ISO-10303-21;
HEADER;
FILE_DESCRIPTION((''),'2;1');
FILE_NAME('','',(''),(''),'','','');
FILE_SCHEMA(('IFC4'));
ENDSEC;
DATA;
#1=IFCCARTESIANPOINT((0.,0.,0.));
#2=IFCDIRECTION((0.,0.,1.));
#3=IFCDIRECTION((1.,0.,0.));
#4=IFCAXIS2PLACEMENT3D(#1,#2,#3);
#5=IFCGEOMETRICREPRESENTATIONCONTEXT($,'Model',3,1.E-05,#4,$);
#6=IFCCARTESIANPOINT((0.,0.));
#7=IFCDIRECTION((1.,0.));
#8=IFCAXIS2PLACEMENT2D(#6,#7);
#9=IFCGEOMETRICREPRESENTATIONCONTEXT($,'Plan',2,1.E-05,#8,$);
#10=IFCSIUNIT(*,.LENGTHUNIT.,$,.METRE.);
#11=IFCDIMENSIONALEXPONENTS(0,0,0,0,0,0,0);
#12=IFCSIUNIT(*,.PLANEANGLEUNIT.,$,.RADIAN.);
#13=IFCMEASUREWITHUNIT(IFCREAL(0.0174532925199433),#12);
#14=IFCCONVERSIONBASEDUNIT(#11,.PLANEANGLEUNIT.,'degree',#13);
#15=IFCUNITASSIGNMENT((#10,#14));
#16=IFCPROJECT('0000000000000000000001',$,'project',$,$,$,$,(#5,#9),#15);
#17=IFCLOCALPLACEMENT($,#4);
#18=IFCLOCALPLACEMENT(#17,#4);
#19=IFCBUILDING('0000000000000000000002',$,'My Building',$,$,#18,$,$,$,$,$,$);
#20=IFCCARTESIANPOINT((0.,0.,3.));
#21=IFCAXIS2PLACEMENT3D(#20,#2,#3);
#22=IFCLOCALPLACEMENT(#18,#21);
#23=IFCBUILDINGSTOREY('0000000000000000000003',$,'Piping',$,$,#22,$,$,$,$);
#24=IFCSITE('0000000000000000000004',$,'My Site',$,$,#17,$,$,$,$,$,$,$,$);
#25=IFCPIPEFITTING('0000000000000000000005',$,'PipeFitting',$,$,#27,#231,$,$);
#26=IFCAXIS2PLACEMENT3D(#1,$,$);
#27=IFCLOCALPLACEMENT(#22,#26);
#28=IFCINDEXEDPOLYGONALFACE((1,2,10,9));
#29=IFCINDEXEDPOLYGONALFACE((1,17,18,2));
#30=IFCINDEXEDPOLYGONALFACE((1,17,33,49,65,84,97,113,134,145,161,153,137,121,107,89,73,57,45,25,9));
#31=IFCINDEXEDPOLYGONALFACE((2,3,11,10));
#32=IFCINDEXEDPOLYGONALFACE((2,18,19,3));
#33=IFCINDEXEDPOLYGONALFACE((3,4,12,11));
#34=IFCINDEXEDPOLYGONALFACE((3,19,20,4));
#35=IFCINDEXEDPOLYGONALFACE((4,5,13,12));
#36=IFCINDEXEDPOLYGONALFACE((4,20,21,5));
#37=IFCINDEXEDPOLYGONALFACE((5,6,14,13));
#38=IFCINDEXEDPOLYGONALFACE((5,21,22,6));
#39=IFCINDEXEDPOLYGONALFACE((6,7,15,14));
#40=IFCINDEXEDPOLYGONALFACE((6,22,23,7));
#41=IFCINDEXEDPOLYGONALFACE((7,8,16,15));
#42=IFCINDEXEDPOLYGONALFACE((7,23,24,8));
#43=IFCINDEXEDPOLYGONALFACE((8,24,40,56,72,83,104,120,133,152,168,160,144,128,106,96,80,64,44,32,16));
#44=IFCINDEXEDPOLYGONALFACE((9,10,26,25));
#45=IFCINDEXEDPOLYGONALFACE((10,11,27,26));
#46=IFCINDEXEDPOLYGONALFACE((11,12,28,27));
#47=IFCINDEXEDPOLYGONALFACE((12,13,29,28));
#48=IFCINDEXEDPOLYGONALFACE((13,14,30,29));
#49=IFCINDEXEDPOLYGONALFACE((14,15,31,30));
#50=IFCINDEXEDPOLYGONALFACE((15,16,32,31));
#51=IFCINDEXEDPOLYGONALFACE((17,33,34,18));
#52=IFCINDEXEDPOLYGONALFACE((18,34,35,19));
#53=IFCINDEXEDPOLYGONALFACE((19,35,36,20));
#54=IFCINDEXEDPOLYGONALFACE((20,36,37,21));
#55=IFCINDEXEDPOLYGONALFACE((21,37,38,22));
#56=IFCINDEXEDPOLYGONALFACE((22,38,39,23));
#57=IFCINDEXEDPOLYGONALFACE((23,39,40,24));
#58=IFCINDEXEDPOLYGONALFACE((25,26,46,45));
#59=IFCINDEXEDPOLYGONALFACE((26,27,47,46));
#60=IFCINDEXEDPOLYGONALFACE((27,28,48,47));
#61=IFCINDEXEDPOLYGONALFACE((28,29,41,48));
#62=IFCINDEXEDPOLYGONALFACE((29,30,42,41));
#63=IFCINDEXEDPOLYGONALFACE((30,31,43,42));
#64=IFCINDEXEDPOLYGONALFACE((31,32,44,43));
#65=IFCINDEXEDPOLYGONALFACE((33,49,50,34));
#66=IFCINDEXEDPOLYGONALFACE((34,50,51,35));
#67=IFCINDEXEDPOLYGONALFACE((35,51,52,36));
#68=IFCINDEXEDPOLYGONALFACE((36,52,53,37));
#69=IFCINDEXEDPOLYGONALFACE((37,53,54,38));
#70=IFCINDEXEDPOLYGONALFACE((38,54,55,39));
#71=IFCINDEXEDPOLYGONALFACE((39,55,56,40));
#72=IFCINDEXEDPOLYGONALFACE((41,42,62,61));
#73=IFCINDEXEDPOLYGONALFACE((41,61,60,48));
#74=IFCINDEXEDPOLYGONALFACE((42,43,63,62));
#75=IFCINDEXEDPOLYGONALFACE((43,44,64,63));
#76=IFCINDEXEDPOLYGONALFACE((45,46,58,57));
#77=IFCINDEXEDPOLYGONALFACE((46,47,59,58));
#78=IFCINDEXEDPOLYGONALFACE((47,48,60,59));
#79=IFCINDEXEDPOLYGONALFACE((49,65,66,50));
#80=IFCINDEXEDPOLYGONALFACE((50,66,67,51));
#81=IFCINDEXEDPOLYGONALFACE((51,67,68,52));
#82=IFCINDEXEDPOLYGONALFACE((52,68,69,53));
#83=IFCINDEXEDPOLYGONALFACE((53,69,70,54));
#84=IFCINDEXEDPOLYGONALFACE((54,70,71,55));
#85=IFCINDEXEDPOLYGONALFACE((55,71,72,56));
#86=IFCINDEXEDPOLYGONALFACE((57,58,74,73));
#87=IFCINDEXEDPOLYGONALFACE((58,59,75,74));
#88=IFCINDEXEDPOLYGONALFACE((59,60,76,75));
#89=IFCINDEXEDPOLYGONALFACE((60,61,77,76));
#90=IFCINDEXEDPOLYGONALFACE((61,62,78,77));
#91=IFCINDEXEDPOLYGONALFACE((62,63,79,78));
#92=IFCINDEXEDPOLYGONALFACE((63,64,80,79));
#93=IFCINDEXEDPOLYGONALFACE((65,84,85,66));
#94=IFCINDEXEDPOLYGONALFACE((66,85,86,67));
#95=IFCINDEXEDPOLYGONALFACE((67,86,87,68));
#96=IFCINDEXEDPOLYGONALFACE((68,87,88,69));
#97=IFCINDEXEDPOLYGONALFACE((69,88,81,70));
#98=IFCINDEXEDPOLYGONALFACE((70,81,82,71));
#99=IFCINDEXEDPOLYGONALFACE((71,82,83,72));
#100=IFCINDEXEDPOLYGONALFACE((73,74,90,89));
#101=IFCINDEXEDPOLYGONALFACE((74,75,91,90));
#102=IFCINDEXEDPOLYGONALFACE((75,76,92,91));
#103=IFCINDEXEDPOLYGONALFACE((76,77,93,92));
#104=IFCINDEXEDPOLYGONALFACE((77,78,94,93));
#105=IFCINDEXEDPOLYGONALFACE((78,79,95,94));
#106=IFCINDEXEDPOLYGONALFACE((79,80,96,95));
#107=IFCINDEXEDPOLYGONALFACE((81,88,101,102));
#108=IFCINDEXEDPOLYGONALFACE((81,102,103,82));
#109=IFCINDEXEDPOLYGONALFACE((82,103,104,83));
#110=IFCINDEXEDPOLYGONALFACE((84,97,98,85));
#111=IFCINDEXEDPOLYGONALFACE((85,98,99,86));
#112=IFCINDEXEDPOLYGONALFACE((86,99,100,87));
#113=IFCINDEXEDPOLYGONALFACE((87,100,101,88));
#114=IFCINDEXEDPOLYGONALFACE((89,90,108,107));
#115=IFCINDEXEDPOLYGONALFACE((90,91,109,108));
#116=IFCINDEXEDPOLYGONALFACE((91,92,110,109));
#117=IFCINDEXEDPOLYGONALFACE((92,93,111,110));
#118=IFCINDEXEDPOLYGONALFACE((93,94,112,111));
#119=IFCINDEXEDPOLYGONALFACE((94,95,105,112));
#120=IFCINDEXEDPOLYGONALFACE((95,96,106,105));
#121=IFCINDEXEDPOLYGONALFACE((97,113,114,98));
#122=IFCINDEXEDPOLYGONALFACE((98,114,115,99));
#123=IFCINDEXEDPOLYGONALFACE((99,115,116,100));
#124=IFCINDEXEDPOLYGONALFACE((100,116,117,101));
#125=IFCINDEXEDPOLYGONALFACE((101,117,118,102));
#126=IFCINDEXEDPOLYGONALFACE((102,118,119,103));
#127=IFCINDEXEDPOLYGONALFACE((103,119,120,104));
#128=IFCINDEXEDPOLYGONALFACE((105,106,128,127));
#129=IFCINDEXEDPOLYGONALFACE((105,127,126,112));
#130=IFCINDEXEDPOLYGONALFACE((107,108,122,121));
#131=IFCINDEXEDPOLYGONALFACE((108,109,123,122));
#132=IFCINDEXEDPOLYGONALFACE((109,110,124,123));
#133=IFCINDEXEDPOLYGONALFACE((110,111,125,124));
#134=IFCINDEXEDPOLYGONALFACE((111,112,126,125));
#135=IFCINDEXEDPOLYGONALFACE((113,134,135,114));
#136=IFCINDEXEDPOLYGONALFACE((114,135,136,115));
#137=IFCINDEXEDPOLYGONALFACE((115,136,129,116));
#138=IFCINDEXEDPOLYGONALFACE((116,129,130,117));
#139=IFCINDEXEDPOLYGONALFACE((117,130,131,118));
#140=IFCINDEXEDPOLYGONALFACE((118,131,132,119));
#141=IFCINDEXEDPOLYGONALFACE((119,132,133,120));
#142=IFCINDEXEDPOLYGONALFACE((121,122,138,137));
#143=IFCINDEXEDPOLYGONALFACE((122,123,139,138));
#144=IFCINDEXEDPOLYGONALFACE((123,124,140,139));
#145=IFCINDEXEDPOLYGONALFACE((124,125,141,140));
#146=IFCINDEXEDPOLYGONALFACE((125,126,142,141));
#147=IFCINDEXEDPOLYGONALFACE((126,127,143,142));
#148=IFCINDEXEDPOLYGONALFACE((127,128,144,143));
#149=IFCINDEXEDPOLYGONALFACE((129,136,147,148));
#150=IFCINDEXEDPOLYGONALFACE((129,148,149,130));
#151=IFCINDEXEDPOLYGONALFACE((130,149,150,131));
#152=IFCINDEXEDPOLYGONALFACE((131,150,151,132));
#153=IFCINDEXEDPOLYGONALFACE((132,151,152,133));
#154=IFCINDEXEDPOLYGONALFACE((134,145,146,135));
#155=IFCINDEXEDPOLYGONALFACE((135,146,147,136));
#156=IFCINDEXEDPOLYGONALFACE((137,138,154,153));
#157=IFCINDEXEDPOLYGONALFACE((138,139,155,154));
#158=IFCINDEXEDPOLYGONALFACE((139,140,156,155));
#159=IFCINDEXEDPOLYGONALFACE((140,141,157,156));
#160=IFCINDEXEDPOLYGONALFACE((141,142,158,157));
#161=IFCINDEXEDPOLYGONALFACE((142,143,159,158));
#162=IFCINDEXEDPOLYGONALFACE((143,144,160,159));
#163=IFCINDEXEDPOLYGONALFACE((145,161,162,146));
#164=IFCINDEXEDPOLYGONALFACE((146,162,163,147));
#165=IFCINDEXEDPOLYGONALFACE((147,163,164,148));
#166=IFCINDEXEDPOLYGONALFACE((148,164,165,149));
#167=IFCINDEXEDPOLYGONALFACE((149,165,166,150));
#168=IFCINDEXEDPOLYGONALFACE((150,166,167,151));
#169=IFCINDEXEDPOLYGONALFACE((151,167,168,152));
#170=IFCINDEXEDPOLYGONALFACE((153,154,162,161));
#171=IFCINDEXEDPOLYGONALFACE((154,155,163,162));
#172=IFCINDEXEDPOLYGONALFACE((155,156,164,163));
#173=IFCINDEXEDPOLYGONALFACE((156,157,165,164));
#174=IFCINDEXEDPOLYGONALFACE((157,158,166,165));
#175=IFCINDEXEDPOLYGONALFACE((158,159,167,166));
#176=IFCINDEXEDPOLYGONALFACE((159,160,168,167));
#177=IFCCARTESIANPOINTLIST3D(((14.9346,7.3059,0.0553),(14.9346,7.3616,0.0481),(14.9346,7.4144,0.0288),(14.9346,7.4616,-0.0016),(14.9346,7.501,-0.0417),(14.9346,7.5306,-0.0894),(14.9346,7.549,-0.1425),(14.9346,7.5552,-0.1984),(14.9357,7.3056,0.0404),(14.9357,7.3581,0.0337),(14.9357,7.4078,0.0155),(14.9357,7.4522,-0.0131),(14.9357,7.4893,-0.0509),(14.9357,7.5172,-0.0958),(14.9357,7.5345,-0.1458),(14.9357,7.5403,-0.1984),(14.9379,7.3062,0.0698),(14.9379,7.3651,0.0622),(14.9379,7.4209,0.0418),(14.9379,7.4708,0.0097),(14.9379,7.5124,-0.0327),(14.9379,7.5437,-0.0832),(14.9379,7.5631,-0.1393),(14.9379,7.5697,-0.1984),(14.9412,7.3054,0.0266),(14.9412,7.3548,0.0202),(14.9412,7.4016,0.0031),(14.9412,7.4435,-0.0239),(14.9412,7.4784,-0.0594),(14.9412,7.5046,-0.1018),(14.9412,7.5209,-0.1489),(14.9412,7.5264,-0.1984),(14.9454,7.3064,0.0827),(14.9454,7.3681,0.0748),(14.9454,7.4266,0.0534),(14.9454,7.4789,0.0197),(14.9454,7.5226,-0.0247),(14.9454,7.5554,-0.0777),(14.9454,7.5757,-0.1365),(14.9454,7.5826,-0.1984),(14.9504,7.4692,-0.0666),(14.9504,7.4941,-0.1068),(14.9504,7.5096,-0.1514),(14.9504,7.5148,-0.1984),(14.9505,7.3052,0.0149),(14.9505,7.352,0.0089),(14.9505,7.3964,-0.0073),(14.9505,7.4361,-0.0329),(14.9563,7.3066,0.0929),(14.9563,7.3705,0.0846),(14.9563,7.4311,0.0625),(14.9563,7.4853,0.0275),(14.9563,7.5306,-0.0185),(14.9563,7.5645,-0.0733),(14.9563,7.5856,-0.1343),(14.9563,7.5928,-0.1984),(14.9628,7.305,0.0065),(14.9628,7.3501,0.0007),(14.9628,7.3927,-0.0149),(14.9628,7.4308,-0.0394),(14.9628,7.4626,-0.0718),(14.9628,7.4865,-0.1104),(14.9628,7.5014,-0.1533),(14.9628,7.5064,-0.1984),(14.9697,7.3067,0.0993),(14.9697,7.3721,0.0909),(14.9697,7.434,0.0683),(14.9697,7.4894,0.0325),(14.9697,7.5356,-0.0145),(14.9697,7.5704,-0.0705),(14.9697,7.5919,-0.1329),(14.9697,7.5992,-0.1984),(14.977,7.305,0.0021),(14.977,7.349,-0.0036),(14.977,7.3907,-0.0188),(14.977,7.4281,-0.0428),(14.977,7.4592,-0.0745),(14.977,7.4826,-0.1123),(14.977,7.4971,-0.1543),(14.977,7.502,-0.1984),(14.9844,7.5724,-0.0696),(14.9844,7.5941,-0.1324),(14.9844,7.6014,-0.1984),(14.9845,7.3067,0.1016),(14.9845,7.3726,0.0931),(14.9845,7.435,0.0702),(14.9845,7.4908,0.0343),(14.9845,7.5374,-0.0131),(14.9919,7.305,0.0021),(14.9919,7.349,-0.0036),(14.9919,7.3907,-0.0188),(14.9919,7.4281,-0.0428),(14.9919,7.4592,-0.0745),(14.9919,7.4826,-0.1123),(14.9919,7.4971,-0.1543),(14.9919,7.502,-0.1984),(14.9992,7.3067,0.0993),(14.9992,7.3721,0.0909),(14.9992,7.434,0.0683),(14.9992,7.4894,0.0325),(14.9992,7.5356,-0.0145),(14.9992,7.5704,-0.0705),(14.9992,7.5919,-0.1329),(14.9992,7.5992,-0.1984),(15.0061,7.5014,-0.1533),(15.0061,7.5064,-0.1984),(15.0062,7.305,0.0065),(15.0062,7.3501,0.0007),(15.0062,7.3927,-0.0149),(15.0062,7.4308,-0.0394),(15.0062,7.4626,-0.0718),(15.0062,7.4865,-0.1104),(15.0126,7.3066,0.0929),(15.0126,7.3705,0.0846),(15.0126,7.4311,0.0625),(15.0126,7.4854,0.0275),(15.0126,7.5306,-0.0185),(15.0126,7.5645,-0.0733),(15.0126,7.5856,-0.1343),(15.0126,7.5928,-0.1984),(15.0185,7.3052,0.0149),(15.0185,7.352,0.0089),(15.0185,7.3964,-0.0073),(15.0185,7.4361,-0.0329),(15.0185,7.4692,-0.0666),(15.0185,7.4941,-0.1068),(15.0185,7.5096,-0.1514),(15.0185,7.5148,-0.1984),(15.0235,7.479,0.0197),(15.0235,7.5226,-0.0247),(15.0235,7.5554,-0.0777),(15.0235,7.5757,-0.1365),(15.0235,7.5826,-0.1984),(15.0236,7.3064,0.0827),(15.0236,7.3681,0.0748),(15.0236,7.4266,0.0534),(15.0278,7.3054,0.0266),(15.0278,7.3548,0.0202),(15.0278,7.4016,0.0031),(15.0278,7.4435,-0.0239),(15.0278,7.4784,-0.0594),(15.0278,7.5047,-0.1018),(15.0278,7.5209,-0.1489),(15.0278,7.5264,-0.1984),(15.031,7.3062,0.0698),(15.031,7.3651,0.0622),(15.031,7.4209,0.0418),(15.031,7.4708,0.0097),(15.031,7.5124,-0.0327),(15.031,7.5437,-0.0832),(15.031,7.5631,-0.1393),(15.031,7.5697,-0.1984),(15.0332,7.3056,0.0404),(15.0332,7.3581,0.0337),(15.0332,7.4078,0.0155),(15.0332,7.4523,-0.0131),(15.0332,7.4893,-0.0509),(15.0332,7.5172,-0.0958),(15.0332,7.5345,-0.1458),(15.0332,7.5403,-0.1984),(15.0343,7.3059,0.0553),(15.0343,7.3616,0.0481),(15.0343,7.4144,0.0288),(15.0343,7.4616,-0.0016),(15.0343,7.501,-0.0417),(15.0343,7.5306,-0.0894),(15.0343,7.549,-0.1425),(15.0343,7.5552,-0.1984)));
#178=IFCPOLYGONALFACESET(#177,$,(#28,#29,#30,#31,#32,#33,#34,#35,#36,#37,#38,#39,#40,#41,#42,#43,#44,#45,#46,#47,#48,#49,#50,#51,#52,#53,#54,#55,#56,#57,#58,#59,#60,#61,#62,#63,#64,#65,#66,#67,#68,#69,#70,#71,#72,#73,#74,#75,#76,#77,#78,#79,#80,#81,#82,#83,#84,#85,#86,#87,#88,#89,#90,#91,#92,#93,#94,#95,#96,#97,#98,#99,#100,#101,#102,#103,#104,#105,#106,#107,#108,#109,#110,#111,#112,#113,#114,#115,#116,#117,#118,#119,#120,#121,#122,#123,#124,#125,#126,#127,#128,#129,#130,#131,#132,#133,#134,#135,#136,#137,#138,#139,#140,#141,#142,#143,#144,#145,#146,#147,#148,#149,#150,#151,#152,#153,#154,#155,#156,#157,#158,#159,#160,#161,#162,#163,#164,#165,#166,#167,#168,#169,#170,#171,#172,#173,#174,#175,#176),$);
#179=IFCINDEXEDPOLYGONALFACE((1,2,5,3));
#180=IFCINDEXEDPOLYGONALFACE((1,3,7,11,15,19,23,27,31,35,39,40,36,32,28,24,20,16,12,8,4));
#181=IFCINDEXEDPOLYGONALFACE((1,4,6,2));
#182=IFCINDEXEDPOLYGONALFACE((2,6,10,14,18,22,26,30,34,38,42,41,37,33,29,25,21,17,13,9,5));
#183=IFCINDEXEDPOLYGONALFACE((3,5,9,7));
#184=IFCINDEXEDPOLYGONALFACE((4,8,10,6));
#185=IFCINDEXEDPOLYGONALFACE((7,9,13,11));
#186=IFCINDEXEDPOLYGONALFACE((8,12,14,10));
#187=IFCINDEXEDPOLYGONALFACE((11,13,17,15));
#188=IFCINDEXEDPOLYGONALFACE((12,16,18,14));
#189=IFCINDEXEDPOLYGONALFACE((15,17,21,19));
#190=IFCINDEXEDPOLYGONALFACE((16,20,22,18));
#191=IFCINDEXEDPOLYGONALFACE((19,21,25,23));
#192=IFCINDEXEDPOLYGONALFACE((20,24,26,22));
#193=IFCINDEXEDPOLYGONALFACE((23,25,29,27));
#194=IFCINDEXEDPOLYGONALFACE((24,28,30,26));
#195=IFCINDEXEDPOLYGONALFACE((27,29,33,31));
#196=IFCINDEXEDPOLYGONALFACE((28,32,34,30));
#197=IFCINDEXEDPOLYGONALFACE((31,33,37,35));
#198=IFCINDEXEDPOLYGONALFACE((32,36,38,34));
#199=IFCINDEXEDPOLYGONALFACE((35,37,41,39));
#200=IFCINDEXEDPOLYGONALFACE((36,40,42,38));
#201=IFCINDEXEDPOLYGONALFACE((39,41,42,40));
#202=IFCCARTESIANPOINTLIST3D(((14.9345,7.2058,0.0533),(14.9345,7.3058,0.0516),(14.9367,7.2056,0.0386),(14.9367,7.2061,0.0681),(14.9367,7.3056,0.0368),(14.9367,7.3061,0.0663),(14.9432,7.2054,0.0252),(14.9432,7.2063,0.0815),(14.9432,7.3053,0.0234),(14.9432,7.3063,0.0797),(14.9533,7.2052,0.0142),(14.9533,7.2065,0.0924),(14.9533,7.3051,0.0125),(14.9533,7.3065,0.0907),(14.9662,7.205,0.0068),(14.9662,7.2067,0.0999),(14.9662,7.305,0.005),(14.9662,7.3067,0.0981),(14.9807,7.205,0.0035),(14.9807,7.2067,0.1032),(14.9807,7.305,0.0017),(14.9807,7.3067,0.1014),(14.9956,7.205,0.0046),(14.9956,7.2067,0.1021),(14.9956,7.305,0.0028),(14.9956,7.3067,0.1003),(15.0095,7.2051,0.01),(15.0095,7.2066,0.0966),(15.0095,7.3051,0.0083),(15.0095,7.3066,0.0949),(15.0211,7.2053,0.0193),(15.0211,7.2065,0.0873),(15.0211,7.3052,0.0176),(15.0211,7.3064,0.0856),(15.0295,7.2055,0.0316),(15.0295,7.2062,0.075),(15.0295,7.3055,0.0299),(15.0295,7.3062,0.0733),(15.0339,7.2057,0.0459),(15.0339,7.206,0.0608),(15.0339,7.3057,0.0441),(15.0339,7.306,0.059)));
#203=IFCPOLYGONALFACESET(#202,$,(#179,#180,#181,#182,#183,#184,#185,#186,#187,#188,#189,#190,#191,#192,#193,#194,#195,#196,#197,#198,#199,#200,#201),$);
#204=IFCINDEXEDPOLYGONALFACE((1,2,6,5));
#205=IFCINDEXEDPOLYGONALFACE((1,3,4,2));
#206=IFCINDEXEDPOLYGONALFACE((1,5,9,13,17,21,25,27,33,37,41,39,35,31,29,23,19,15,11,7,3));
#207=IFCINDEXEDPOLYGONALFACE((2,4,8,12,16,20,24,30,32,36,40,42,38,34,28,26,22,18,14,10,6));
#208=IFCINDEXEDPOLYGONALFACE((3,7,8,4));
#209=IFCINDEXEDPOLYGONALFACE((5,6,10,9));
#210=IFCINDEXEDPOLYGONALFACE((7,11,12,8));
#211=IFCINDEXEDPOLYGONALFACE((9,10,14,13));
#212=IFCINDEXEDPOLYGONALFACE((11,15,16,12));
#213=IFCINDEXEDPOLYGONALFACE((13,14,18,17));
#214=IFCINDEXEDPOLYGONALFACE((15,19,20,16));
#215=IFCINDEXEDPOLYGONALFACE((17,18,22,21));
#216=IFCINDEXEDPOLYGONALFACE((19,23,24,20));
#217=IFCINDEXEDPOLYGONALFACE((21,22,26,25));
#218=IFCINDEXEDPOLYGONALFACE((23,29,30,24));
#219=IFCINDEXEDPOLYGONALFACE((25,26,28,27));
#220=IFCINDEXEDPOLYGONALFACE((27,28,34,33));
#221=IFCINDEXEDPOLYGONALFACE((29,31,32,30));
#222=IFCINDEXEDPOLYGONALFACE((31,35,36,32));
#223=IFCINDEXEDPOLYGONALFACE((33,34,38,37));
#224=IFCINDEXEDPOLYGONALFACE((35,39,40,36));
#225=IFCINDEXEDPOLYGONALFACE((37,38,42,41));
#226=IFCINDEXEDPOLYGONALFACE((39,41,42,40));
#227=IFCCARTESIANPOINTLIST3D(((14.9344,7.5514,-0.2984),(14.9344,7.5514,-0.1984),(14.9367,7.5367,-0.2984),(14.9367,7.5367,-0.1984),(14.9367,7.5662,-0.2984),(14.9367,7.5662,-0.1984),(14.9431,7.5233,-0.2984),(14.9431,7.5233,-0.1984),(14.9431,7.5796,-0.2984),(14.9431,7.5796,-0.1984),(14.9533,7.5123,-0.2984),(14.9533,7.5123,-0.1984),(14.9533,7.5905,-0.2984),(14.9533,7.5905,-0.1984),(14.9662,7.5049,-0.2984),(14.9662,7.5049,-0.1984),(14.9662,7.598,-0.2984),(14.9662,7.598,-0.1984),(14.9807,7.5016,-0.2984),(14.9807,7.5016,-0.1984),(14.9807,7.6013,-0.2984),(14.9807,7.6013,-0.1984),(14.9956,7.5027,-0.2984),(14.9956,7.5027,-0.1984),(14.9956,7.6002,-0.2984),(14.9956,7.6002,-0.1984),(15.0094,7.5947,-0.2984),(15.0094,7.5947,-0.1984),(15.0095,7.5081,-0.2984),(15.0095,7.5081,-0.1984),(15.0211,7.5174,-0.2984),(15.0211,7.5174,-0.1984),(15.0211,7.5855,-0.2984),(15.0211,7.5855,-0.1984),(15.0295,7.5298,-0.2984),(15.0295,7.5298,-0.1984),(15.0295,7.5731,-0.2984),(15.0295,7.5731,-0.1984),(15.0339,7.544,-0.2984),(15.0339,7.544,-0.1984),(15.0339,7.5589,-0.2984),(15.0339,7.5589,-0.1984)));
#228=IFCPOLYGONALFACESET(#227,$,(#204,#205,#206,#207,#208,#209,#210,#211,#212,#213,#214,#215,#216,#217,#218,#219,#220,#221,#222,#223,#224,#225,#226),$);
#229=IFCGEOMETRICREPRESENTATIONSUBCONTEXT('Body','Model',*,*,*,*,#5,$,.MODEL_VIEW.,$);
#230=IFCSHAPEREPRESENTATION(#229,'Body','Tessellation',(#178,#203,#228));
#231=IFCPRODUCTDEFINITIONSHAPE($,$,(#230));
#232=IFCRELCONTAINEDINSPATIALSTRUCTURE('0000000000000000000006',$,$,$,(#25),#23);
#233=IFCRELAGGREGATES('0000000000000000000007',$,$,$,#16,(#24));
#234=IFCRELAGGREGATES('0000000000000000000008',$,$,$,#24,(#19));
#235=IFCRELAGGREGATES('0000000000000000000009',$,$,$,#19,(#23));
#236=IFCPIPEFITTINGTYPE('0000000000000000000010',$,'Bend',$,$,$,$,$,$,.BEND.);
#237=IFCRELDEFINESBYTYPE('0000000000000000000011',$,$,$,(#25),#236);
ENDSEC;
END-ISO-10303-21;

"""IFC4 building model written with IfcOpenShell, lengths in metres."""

from ifc_helpers import new_model, entity, si_unit, converted_unit, frame, origin_with_axes, origin_2d_with_axis, place, context, subcontext, project, spatial, circle, extrude, source, transform, mapped, type_object, type_shapes, element, save


model = new_model("IFC4")

# Units and contexts
model_context = context("Model", 3, precision=1e-05, world=origin_with_axes())
plan_context = context("Plan", 2, precision=1e-05, world=origin_2d_with_axis())
body_context = subcontext(model_context, "Body", "Model", "MODEL_VIEW")
ifc_project = project(units=[si_unit("LENGTHUNIT", "METRE"), converted_unit("PLANEANGLEUNIT", "degree", entity("IfcReal", 0.0174532925199433), si_unit("PLANEANGLEUNIT", "RADIAN"), dimensions=[0, 0, 0, 0, 0, 0, 0])], contexts=[model_context, plan_context])

# Site, building, storey
site_placement = place(None, origin_with_axes())
site = spatial("IfcSite", under=ifc_project, at=site_placement, Name="My Site")
building_placement = place(site_placement, origin_with_axes())
building = spatial("IfcBuilding", under=site, at=building_placement, Name="My Building")
storey_placement = place(building_placement, frame((0.0, 0.0, 3.0), z_axis=(0.0, 0.0, 1.0), x_axis=(1.0, 0.0, 0.0)))
storey = spatial("IfcBuildingStorey", under=building, at=storey_placement, Name="Piping")

# Pipe fitting
pipe_fitting_type_1 = type_object("IfcPipeFittingType", Name="Bend", PredefinedType="BEND")
shared_shape_1 = source(origin_with_axes(), body_context, "Body", "SolidModel", [
    entity("IfcSweptDiskSolid", entity("IfcIndexedPolyCurve", entity("IfcCartesianPointList3D", [[0.0, 0.0, 0.1], [0.0, -0.0717, 0.2752], [0.0, -0.2456, 0.35]]), [entity("IfcArcIndex", [1, 2, 3])]), 0.05),
    extrude(circle(Radius=0.05), origin_with_axes(), (0.0, 0.0, 1.0), 0.1),
    extrude(circle(Radius=0.05), frame((0.0, -0.2456, 0.35), z_axis=(0.0, -0.999846, 0.017575), x_axis=(1.0, 0.0, 0.0)), (0.0, 0.0, 1.0), 0.1),
])
type_shapes(pipe_fitting_type_1, [shared_shape_1])
for number, where, z_axis, x_axis, name in (
    (1, (14.9845, 7.2059, 0.0533), (-0.000099, 0.999846, -0.017575), (-1.0, -0.000099, 0.0), "PipeFitting"),
):
    element("IfcPipeFitting", number, at=place(storey_placement, frame(where, z_axis=z_axis, x_axis=x_axis)), inside=storey, type_object=pipe_fitting_type_1, Name=name, context=body_context, shape_type="MappedRepresentation", body=[
        mapped(shared_shape_1, transform((0.0, 0.0, 0.0), x_axis=(1.0, 0.0, 0.0), y_axis=(0.0, 1.0, 0.0), z_axis=(0.0, 0.0, 1.0), scale=1.0)),
    ])

save(model, "model.ifc")
